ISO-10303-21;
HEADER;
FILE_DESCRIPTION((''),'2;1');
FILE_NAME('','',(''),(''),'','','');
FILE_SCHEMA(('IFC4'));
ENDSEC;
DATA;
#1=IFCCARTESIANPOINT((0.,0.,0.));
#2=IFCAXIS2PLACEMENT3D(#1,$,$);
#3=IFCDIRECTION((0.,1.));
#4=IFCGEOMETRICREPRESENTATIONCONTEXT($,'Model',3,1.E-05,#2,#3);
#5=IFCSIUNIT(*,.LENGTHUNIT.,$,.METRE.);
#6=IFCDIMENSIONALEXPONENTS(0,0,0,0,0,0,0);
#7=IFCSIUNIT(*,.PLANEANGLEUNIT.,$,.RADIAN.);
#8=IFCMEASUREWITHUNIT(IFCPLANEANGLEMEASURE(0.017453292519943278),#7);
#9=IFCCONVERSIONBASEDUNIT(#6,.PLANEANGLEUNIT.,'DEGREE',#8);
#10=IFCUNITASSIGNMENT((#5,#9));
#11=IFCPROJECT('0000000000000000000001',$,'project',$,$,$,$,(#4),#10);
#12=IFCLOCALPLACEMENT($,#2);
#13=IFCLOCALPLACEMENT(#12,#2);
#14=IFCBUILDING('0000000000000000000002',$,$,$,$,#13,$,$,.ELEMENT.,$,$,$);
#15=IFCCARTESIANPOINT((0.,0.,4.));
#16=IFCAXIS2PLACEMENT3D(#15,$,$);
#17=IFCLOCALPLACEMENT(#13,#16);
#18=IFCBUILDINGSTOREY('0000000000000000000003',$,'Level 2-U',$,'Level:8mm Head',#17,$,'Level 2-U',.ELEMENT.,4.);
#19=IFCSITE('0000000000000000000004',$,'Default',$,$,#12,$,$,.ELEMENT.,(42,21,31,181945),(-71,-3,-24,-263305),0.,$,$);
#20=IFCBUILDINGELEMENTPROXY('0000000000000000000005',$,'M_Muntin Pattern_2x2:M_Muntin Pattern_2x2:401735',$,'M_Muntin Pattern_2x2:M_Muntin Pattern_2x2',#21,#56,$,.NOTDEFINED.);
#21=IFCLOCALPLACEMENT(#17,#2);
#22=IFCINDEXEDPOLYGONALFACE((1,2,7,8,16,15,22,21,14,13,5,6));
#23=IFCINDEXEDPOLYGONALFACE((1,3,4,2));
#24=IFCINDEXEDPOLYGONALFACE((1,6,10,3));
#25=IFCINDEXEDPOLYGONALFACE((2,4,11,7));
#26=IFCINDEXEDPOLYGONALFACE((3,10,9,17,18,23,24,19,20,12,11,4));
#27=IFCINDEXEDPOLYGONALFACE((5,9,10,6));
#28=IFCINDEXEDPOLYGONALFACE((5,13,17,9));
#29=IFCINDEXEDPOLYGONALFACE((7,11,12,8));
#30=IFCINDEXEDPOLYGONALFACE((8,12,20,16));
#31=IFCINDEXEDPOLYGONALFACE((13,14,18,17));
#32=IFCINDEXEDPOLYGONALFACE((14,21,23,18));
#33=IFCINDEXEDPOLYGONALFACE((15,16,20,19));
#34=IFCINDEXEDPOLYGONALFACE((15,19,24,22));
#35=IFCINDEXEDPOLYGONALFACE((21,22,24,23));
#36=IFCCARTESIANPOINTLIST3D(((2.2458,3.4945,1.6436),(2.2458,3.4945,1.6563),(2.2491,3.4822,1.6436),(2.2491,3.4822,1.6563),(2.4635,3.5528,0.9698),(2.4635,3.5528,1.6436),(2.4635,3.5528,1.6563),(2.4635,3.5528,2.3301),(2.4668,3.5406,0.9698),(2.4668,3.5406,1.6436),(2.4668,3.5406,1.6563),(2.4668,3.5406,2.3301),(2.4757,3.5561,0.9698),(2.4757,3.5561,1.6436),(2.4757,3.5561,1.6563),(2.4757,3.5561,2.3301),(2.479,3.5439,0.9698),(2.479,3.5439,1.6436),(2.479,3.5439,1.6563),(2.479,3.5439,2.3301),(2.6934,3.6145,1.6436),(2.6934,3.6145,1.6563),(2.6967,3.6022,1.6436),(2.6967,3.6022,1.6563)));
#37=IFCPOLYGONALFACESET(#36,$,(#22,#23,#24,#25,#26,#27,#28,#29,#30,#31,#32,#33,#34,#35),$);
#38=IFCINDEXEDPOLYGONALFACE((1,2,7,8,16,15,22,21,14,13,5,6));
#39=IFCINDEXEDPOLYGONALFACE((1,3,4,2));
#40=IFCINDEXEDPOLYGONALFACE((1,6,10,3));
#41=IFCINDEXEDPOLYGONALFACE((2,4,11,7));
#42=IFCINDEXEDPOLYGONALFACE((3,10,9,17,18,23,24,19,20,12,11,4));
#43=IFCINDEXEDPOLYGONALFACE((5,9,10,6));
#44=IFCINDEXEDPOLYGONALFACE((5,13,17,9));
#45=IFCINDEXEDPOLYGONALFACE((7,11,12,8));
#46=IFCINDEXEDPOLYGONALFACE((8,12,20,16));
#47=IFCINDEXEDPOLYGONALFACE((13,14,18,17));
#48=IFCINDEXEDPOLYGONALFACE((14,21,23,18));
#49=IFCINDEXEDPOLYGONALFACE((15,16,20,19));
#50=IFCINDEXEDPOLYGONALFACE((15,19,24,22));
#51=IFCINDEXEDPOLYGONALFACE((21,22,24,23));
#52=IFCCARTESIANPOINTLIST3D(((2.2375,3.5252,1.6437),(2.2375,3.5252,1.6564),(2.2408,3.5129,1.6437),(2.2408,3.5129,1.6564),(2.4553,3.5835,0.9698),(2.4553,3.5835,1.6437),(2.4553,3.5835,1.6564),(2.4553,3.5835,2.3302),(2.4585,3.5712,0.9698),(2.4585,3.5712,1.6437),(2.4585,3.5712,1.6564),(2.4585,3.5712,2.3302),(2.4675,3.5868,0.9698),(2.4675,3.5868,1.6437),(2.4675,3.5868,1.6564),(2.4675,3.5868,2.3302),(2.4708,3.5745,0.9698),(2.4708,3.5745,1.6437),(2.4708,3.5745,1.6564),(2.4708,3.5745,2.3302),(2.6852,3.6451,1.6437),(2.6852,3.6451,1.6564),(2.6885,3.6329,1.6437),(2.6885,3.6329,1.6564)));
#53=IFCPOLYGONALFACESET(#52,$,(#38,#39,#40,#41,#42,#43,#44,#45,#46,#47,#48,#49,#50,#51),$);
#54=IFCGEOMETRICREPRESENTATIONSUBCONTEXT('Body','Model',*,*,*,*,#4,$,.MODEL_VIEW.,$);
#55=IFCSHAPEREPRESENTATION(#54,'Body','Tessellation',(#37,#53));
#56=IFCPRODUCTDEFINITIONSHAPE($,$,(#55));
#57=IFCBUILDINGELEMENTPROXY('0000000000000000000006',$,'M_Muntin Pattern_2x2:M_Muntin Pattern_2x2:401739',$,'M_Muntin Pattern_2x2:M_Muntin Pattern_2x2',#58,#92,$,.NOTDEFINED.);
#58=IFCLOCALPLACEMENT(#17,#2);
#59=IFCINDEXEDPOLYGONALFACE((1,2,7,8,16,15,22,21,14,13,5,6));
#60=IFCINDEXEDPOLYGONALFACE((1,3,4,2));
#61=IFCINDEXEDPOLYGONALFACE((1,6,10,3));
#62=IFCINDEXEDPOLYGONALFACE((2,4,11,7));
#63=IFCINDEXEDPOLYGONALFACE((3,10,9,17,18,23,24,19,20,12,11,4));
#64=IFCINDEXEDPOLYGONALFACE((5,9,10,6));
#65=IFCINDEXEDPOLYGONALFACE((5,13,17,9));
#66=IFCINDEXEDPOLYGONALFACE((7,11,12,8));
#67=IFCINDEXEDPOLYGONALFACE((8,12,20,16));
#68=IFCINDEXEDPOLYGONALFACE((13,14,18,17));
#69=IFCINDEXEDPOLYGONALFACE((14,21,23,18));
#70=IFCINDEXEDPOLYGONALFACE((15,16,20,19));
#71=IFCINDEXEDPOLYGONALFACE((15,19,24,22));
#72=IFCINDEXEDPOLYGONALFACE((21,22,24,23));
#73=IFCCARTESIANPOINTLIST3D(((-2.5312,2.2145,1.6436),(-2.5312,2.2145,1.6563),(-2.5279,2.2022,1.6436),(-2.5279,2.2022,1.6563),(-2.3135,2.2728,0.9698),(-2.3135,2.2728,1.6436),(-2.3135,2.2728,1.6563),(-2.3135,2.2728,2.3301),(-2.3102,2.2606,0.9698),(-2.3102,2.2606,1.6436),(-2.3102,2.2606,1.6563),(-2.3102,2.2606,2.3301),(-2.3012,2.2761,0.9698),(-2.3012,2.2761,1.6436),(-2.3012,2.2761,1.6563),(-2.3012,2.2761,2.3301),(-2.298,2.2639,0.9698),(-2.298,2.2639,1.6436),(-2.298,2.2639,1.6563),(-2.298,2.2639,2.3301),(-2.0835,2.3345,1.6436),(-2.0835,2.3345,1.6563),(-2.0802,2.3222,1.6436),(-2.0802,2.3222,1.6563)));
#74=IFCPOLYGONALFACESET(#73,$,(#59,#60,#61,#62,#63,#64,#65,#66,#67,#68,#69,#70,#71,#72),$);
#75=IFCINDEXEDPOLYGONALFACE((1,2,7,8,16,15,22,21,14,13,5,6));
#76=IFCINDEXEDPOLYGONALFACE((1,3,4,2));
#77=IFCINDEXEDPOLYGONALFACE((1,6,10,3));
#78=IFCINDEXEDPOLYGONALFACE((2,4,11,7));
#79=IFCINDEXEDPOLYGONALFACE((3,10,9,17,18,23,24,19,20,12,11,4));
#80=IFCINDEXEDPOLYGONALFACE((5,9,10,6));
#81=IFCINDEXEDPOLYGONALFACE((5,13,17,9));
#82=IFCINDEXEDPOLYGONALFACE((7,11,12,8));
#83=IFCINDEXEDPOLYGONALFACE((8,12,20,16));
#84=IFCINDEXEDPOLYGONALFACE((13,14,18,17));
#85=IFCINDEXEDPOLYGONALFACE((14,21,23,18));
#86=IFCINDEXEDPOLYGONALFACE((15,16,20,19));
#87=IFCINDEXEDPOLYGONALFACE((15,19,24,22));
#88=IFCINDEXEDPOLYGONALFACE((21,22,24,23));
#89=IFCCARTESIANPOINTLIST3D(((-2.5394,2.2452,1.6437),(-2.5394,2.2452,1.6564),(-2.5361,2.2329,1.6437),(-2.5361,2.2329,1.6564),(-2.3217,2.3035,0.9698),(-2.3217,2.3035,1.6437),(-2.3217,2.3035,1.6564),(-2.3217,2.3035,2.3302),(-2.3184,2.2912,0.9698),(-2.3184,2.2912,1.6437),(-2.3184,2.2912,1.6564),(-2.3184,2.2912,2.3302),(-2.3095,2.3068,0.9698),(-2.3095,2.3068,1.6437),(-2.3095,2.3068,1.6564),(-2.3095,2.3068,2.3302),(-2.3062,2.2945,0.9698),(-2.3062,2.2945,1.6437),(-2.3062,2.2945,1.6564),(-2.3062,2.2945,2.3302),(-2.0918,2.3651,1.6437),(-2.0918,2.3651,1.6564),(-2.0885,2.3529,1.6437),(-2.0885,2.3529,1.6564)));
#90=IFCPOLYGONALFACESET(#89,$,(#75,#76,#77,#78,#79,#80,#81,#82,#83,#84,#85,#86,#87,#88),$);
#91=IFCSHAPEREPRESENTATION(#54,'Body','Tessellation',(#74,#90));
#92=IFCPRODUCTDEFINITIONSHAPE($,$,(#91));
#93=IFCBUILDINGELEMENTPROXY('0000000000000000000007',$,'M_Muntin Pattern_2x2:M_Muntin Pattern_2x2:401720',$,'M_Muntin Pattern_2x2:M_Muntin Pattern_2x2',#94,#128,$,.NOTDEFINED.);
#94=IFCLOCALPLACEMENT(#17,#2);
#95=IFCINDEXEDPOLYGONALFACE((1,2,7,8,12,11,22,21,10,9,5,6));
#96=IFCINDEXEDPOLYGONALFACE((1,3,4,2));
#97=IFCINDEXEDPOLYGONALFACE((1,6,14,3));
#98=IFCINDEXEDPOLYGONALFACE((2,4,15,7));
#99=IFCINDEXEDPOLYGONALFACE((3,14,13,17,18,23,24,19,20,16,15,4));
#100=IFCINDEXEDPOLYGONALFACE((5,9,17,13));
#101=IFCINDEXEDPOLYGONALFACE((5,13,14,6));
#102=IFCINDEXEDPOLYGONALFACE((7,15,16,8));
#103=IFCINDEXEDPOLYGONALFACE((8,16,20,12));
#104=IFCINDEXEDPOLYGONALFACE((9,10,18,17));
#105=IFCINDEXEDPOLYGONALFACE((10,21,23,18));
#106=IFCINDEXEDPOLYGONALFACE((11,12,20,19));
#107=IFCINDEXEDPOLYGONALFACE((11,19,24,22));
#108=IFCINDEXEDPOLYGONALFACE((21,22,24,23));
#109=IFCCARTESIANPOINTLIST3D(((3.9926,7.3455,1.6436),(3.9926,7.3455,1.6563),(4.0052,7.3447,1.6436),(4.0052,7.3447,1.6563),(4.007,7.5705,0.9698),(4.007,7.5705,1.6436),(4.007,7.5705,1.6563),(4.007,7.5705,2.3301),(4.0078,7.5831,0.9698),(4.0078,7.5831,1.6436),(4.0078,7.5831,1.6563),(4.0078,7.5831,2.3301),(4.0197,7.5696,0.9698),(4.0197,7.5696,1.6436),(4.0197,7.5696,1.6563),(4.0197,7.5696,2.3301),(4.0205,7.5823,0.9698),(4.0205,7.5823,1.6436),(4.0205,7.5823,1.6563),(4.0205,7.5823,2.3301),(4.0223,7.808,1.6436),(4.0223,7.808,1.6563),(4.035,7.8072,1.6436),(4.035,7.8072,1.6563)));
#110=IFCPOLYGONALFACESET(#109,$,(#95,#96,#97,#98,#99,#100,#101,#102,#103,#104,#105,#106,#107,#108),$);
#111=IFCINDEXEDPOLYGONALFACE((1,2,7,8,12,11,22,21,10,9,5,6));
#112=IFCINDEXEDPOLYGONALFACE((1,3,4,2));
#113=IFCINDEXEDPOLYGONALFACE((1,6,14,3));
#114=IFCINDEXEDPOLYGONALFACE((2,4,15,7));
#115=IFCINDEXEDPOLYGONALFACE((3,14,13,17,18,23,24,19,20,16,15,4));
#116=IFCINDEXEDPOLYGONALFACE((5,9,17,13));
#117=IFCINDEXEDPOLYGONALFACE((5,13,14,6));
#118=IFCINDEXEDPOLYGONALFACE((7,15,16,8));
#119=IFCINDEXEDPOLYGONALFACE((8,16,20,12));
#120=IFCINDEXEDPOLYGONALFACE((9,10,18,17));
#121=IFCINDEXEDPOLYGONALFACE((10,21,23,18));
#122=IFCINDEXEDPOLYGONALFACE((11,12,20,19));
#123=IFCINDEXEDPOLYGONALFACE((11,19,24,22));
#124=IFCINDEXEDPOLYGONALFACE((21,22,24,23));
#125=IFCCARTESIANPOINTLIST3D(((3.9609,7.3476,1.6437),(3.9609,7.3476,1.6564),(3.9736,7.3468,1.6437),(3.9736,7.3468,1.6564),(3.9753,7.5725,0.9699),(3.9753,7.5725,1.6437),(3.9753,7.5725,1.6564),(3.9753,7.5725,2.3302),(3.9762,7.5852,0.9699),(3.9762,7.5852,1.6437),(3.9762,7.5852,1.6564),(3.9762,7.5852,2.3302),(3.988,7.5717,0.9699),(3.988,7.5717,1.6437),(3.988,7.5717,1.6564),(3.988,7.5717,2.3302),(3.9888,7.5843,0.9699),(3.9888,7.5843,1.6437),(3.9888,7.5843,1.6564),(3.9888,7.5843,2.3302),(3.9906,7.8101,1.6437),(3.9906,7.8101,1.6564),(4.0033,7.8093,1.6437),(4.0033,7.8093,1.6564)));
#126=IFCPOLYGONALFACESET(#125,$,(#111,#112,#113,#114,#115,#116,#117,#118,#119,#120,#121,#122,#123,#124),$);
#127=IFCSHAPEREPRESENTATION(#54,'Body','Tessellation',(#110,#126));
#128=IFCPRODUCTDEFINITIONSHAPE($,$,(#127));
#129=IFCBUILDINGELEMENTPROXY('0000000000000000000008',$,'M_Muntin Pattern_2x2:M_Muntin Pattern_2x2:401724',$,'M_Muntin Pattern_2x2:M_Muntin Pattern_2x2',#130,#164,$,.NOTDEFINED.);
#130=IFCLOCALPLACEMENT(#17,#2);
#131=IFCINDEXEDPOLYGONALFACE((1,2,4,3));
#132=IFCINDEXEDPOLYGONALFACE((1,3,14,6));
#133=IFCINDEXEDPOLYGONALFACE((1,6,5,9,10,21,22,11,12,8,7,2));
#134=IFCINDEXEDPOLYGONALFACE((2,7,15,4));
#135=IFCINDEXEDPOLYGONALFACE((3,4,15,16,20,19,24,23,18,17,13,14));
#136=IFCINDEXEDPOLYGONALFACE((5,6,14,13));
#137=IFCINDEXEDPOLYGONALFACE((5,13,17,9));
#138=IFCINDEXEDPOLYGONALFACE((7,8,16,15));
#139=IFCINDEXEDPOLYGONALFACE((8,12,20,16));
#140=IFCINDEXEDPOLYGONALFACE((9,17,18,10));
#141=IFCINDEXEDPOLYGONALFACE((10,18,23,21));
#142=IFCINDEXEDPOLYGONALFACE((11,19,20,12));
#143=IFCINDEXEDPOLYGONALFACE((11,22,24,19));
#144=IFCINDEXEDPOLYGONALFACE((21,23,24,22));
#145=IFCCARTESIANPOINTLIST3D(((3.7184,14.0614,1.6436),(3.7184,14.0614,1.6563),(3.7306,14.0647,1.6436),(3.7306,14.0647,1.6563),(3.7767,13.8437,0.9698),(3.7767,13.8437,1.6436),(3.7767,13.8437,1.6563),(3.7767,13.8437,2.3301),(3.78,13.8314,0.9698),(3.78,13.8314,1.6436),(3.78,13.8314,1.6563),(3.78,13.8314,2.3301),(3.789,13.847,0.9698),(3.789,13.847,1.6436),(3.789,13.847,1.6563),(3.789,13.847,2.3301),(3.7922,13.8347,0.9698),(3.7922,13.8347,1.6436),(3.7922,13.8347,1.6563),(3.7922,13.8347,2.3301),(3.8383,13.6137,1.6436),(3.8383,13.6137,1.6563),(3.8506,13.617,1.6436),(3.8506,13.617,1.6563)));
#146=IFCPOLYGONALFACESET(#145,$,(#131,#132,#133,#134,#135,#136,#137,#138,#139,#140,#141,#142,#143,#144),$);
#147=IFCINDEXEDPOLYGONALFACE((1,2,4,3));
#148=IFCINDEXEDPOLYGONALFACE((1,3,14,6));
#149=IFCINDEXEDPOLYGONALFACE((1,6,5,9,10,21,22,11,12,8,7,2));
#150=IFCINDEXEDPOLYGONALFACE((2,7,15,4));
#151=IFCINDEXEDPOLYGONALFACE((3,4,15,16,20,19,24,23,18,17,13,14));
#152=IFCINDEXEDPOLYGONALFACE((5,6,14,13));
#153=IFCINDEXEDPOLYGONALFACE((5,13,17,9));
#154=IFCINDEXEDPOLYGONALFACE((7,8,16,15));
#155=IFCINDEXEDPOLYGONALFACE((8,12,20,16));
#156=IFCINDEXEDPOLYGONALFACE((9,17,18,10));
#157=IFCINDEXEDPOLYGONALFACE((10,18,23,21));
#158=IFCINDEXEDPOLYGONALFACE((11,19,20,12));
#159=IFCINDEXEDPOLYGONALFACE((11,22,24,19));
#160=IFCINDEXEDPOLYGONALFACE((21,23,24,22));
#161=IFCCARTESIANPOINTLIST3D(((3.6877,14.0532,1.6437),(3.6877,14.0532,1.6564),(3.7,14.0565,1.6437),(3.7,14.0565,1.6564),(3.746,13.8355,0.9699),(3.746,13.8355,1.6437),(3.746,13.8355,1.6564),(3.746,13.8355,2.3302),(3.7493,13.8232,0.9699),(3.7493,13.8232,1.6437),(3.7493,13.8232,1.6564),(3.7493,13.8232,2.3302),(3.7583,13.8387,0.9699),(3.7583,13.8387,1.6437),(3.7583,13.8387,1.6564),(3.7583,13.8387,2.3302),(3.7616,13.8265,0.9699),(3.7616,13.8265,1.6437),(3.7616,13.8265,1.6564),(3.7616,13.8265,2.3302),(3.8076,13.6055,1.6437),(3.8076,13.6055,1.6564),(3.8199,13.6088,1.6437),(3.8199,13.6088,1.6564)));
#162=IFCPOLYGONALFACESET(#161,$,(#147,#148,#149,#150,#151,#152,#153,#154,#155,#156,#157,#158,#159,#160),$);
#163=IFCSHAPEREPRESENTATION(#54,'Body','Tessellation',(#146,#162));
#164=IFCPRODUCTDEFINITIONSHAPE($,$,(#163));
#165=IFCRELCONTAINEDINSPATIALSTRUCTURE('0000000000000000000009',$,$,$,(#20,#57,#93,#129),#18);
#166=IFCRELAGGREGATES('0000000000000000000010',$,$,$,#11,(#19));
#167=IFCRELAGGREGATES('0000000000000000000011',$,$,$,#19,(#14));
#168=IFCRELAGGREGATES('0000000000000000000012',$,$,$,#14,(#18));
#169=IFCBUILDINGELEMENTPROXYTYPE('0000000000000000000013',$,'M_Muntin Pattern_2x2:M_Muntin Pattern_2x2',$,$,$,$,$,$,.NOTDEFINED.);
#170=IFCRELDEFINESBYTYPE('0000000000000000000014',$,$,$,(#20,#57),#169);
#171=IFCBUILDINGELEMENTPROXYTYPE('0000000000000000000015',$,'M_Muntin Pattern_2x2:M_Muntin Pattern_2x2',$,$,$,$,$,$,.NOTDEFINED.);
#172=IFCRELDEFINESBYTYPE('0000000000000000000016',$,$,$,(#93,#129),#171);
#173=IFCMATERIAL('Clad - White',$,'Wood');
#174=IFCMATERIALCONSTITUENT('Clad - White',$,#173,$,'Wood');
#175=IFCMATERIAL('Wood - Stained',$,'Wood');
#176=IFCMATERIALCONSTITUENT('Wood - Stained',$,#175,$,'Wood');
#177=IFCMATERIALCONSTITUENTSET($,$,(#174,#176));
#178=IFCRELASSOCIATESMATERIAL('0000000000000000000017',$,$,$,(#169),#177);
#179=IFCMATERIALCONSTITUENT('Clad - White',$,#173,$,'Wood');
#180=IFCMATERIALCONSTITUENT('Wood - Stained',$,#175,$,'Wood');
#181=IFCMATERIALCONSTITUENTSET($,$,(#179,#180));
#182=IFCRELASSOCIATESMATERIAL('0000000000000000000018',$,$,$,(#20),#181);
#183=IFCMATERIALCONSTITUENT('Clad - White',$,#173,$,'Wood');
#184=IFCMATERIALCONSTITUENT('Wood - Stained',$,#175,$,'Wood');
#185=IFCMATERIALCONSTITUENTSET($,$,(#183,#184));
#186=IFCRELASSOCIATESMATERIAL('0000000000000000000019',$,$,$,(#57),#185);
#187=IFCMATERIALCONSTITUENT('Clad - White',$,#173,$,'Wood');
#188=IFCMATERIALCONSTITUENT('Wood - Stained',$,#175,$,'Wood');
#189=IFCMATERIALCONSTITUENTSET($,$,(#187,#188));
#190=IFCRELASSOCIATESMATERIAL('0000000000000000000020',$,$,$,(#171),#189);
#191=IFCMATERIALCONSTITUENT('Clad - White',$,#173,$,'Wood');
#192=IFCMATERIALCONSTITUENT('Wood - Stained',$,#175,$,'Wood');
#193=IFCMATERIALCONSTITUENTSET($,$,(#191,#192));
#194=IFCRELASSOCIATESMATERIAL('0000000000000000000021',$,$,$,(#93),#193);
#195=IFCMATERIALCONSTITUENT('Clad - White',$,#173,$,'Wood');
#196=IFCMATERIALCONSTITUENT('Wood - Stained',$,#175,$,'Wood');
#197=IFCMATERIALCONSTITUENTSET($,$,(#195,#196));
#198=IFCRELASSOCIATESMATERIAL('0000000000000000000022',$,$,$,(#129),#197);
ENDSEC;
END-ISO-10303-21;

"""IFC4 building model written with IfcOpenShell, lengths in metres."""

from ifc_helpers import new_model, entity, si_unit, converted_unit, direction, frame, origin, place, context, subcontext, project, spatial, polyline, outline, extrude, source, transform, mapped, material, constituent, constituent_set, type_object, type_shapes, element, save


model = new_model("IFC4")

# Units and contexts
model_context = context("Model", 3, precision=1e-05, world=origin(), true_north=direction((0.0, 1.0)))
body_context = subcontext(model_context, "Body", "Model", "MODEL_VIEW")
ifc_project = project(units=[si_unit("LENGTHUNIT", "METRE"), converted_unit("PLANEANGLEUNIT", "DEGREE", entity("IfcPlaneAngleMeasure", 0.017453292519943278), si_unit("PLANEANGLEUNIT", "RADIAN"), dimensions=[0, 0, 0, 0, 0, 0, 0])], contexts=[model_context])

# Site, building, storey
site_placement = place(None, origin())
site = spatial("IfcSite", under=ifc_project, at=site_placement, Name="Default", CompositionType="ELEMENT", RefLatitude=(42, 21, 31, 181945), RefLongitude=(-71, -3, -24, -263305), RefElevation=0.0)
building_placement = place(site_placement, origin())
building = spatial("IfcBuilding", under=site, at=building_placement, CompositionType="ELEMENT")
storey_placement = place(building_placement, frame((0.0, 0.0, 4.0)))
storey = spatial("IfcBuildingStorey", under=building, at=storey_placement, Name="Level 2-U", ObjectType="Level:8mm Head", LongName="Level 2-U", CompositionType="ELEMENT", Elevation=4.0)

# Building element proxies
ifc_material_1 = material(Name="Clad - White", Category="Wood")
ifc_material_2 = material(Name="Wood - Stained", Category="Wood")
ifc_constituent_1 = constituent(ifc_material_1, Name="Clad - White", Category="Wood")
ifc_constituent_2 = constituent(ifc_material_2, Name="Wood - Stained", Category="Wood")
ifc_constituent_set_1 = constituent_set(constituents=[ifc_constituent_1, ifc_constituent_2])
building_element_proxy_type_1 = type_object("IfcBuildingElementProxyType", Name="M_Muntin Pattern_2x2:M_Muntin Pattern_2x2", PredefinedType="NOTDEFINED", material=ifc_constituent_set_1)
shared_shape_1 = source(origin(), body_context, "Body", "SweptSolid", [
    extrude(outline(polyline([(0.0064, -0.0064), (0.6801, -0.0064), (0.6801, 0.0063), (0.0064, 0.0063), (0.0064, 0.2317), (-0.0063, 0.2317), (-0.0063, 0.0063), (-0.6802, 0.0063), (-0.6802, -0.0064), (-0.0063, -0.0064), (-0.0063, -0.2317), (0.0064, -0.2317), (0.0064, -0.0064)])), frame((0.0, 0.0095, 0.6801), z_axis=(0.0, 1.0, 0.0), x_axis=(0.0, 0.0, 1.0)), (0.0, 0.0, 1.0), 0.0127),
    extrude(outline(polyline([(0.0064, -0.0064), (0.6802, -0.0064), (0.6802, 0.0063), (0.0064, 0.0063), (0.0064, 0.2317), (-0.0063, 0.2317), (-0.0063, 0.0063), (-0.6802, 0.0063), (-0.6802, -0.0064), (-0.0063, -0.0064), (-0.0063, -0.2317), (0.0064, -0.2317), (0.0064, -0.0064)])), frame((0.0, -0.0222, 0.6802), z_axis=(0.0, 1.0, 0.0), x_axis=(0.0, 0.0, 1.0)), (0.0, 0.0, 1.0), 0.0127),
])
type_shapes(building_element_proxy_type_1, [shared_shape_1])
ifc_constituent_3 = constituent(ifc_material_1, Name="Clad - White", Category="Wood")
ifc_constituent_4 = constituent(ifc_material_2, Name="Wood - Stained", Category="Wood")
ifc_constituent_set_2 = constituent_set(constituents=[ifc_constituent_3, ifc_constituent_4])
proxy_1_placement = place(storey_placement, frame((2.4671, 3.5637, 0.9698), z_axis=(0.0, 0.0, 1.0), x_axis=(-0.965926, -0.258819, 0.0)))
element("IfcBuildingElementProxy", 1, at=proxy_1_placement, inside=storey, type_object=building_element_proxy_type_1, material=ifc_constituent_set_2, Name="M_Muntin Pattern_2x2:M_Muntin Pattern_2x2:401735", ObjectType="M_Muntin Pattern_2x2:M_Muntin Pattern_2x2", PredefinedType="NOTDEFINED", context=body_context, shape_type="MappedRepresentation", body=[
    mapped(shared_shape_1, transform((0.0, 0.0, 0.0), scale=1.0)),
])
ifc_constituent_5 = constituent(ifc_material_1, Name="Clad - White", Category="Wood")
ifc_constituent_6 = constituent(ifc_material_2, Name="Wood - Stained", Category="Wood")
ifc_constituent_set_3 = constituent_set(constituents=[ifc_constituent_5, ifc_constituent_6])
proxy_2_placement = place(storey_placement, frame((-2.3098, 2.2837, 0.9698), z_axis=(0.0, 0.0, 1.0), x_axis=(-0.965926, -0.258819, 0.0)))
element("IfcBuildingElementProxy", 2, at=proxy_2_placement, inside=storey, type_object=building_element_proxy_type_1, material=ifc_constituent_set_3, Name="M_Muntin Pattern_2x2:M_Muntin Pattern_2x2:401739", ObjectType="M_Muntin Pattern_2x2:M_Muntin Pattern_2x2", PredefinedType="NOTDEFINED", context=body_context, shape_type="MappedRepresentation", body=[
    mapped(shared_shape_1, transform((0.0, 0.0, 0.0), scale=1.0)),
])
ifc_constituent_7 = constituent(ifc_material_1, Name="Clad - White", Category="Wood")
ifc_constituent_8 = constituent(ifc_material_2, Name="Wood - Stained", Category="Wood")
ifc_constituent_set_4 = constituent_set(constituents=[ifc_constituent_7, ifc_constituent_8])
ifc_constituent_9 = constituent(ifc_material_1, Name="Clad - White", Category="Wood")
ifc_constituent_10 = constituent(ifc_material_2, Name="Wood - Stained", Category="Wood")
ifc_constituent_set_5 = constituent_set(constituents=[ifc_constituent_9, ifc_constituent_10])
building_element_proxy_type_2 = type_object("IfcBuildingElementProxyType", Name="M_Muntin Pattern_2x2:M_Muntin Pattern_2x2", PredefinedType="NOTDEFINED", material=ifc_constituent_set_5)
shared_shape_2 = source(origin(), body_context, "Body", "SweptSolid", [
    extrude(outline(polyline([(0.0064, -0.0064), (0.6801, -0.0064), (0.6801, 0.0063), (0.0064, 0.0063), (0.0064, 0.2317), (-0.0063, 0.2317), (-0.0063, 0.0063), (-0.6802, 0.0063), (-0.6802, -0.0064), (-0.0063, -0.0064), (-0.0063, -0.2317), (0.0064, -0.2317), (0.0064, -0.0064)])), frame((0.0, -0.0222, 0.6801), z_axis=(0.0, 1.0, 0.0), x_axis=(0.0, 0.0, 1.0)), (0.0, 0.0, 1.0), 0.0127),
    extrude(outline(polyline([(0.0064, -0.0064), (0.6802, -0.0064), (0.6802, 0.0063), (0.0064, 0.0063), (0.0064, 0.2317), (-0.0063, 0.2317), (-0.0063, 0.0063), (-0.6802, 0.0063), (-0.6802, -0.0064), (-0.0063, -0.0064), (-0.0063, -0.2317), (0.0064, -0.2317), (0.0064, -0.0064)])), frame((0.0, 0.0095, 0.6802), z_axis=(0.0, 1.0, 0.0), x_axis=(0.0, 0.0, 1.0)), (0.0, 0.0, 1.0), 0.0127),
])
type_shapes(building_element_proxy_type_2, [shared_shape_2])
proxy_3_placement = place(storey_placement, frame((3.9979, 7.5774, 0.9699), z_axis=(0.0, 0.0, 1.0), x_axis=(0.064186, 0.997938, 0.0)))
element("IfcBuildingElementProxy", 3, at=proxy_3_placement, inside=storey, type_object=building_element_proxy_type_2, material=ifc_constituent_set_4, Name="M_Muntin Pattern_2x2:M_Muntin Pattern_2x2:401720", ObjectType="M_Muntin Pattern_2x2:M_Muntin Pattern_2x2", PredefinedType="NOTDEFINED", context=body_context, shape_type="MappedRepresentation", body=[
    mapped(shared_shape_2, transform((0.0, 0.0, 0.0), scale=1.0)),
])
ifc_constituent_11 = constituent(ifc_material_1, Name="Clad - White", Category="Wood")
ifc_constituent_12 = constituent(ifc_material_2, Name="Wood - Stained", Category="Wood")
ifc_constituent_set_6 = constituent_set(constituents=[ifc_constituent_11, ifc_constituent_12])
proxy_4_placement = place(storey_placement, frame((3.7691, 13.8351, 0.9699), z_axis=(0.0, 0.0, 1.0), x_axis=(-0.258819, 0.965926, 0.0)))
element("IfcBuildingElementProxy", 4, at=proxy_4_placement, inside=storey, type_object=building_element_proxy_type_2, material=ifc_constituent_set_6, Name="M_Muntin Pattern_2x2:M_Muntin Pattern_2x2:401724", ObjectType="M_Muntin Pattern_2x2:M_Muntin Pattern_2x2", PredefinedType="NOTDEFINED", context=body_context, shape_type="MappedRepresentation", body=[
    mapped(shared_shape_2, transform((0.0, 0.0, 0.0), scale=1.0)),
])

save(model, "model.ifc")
